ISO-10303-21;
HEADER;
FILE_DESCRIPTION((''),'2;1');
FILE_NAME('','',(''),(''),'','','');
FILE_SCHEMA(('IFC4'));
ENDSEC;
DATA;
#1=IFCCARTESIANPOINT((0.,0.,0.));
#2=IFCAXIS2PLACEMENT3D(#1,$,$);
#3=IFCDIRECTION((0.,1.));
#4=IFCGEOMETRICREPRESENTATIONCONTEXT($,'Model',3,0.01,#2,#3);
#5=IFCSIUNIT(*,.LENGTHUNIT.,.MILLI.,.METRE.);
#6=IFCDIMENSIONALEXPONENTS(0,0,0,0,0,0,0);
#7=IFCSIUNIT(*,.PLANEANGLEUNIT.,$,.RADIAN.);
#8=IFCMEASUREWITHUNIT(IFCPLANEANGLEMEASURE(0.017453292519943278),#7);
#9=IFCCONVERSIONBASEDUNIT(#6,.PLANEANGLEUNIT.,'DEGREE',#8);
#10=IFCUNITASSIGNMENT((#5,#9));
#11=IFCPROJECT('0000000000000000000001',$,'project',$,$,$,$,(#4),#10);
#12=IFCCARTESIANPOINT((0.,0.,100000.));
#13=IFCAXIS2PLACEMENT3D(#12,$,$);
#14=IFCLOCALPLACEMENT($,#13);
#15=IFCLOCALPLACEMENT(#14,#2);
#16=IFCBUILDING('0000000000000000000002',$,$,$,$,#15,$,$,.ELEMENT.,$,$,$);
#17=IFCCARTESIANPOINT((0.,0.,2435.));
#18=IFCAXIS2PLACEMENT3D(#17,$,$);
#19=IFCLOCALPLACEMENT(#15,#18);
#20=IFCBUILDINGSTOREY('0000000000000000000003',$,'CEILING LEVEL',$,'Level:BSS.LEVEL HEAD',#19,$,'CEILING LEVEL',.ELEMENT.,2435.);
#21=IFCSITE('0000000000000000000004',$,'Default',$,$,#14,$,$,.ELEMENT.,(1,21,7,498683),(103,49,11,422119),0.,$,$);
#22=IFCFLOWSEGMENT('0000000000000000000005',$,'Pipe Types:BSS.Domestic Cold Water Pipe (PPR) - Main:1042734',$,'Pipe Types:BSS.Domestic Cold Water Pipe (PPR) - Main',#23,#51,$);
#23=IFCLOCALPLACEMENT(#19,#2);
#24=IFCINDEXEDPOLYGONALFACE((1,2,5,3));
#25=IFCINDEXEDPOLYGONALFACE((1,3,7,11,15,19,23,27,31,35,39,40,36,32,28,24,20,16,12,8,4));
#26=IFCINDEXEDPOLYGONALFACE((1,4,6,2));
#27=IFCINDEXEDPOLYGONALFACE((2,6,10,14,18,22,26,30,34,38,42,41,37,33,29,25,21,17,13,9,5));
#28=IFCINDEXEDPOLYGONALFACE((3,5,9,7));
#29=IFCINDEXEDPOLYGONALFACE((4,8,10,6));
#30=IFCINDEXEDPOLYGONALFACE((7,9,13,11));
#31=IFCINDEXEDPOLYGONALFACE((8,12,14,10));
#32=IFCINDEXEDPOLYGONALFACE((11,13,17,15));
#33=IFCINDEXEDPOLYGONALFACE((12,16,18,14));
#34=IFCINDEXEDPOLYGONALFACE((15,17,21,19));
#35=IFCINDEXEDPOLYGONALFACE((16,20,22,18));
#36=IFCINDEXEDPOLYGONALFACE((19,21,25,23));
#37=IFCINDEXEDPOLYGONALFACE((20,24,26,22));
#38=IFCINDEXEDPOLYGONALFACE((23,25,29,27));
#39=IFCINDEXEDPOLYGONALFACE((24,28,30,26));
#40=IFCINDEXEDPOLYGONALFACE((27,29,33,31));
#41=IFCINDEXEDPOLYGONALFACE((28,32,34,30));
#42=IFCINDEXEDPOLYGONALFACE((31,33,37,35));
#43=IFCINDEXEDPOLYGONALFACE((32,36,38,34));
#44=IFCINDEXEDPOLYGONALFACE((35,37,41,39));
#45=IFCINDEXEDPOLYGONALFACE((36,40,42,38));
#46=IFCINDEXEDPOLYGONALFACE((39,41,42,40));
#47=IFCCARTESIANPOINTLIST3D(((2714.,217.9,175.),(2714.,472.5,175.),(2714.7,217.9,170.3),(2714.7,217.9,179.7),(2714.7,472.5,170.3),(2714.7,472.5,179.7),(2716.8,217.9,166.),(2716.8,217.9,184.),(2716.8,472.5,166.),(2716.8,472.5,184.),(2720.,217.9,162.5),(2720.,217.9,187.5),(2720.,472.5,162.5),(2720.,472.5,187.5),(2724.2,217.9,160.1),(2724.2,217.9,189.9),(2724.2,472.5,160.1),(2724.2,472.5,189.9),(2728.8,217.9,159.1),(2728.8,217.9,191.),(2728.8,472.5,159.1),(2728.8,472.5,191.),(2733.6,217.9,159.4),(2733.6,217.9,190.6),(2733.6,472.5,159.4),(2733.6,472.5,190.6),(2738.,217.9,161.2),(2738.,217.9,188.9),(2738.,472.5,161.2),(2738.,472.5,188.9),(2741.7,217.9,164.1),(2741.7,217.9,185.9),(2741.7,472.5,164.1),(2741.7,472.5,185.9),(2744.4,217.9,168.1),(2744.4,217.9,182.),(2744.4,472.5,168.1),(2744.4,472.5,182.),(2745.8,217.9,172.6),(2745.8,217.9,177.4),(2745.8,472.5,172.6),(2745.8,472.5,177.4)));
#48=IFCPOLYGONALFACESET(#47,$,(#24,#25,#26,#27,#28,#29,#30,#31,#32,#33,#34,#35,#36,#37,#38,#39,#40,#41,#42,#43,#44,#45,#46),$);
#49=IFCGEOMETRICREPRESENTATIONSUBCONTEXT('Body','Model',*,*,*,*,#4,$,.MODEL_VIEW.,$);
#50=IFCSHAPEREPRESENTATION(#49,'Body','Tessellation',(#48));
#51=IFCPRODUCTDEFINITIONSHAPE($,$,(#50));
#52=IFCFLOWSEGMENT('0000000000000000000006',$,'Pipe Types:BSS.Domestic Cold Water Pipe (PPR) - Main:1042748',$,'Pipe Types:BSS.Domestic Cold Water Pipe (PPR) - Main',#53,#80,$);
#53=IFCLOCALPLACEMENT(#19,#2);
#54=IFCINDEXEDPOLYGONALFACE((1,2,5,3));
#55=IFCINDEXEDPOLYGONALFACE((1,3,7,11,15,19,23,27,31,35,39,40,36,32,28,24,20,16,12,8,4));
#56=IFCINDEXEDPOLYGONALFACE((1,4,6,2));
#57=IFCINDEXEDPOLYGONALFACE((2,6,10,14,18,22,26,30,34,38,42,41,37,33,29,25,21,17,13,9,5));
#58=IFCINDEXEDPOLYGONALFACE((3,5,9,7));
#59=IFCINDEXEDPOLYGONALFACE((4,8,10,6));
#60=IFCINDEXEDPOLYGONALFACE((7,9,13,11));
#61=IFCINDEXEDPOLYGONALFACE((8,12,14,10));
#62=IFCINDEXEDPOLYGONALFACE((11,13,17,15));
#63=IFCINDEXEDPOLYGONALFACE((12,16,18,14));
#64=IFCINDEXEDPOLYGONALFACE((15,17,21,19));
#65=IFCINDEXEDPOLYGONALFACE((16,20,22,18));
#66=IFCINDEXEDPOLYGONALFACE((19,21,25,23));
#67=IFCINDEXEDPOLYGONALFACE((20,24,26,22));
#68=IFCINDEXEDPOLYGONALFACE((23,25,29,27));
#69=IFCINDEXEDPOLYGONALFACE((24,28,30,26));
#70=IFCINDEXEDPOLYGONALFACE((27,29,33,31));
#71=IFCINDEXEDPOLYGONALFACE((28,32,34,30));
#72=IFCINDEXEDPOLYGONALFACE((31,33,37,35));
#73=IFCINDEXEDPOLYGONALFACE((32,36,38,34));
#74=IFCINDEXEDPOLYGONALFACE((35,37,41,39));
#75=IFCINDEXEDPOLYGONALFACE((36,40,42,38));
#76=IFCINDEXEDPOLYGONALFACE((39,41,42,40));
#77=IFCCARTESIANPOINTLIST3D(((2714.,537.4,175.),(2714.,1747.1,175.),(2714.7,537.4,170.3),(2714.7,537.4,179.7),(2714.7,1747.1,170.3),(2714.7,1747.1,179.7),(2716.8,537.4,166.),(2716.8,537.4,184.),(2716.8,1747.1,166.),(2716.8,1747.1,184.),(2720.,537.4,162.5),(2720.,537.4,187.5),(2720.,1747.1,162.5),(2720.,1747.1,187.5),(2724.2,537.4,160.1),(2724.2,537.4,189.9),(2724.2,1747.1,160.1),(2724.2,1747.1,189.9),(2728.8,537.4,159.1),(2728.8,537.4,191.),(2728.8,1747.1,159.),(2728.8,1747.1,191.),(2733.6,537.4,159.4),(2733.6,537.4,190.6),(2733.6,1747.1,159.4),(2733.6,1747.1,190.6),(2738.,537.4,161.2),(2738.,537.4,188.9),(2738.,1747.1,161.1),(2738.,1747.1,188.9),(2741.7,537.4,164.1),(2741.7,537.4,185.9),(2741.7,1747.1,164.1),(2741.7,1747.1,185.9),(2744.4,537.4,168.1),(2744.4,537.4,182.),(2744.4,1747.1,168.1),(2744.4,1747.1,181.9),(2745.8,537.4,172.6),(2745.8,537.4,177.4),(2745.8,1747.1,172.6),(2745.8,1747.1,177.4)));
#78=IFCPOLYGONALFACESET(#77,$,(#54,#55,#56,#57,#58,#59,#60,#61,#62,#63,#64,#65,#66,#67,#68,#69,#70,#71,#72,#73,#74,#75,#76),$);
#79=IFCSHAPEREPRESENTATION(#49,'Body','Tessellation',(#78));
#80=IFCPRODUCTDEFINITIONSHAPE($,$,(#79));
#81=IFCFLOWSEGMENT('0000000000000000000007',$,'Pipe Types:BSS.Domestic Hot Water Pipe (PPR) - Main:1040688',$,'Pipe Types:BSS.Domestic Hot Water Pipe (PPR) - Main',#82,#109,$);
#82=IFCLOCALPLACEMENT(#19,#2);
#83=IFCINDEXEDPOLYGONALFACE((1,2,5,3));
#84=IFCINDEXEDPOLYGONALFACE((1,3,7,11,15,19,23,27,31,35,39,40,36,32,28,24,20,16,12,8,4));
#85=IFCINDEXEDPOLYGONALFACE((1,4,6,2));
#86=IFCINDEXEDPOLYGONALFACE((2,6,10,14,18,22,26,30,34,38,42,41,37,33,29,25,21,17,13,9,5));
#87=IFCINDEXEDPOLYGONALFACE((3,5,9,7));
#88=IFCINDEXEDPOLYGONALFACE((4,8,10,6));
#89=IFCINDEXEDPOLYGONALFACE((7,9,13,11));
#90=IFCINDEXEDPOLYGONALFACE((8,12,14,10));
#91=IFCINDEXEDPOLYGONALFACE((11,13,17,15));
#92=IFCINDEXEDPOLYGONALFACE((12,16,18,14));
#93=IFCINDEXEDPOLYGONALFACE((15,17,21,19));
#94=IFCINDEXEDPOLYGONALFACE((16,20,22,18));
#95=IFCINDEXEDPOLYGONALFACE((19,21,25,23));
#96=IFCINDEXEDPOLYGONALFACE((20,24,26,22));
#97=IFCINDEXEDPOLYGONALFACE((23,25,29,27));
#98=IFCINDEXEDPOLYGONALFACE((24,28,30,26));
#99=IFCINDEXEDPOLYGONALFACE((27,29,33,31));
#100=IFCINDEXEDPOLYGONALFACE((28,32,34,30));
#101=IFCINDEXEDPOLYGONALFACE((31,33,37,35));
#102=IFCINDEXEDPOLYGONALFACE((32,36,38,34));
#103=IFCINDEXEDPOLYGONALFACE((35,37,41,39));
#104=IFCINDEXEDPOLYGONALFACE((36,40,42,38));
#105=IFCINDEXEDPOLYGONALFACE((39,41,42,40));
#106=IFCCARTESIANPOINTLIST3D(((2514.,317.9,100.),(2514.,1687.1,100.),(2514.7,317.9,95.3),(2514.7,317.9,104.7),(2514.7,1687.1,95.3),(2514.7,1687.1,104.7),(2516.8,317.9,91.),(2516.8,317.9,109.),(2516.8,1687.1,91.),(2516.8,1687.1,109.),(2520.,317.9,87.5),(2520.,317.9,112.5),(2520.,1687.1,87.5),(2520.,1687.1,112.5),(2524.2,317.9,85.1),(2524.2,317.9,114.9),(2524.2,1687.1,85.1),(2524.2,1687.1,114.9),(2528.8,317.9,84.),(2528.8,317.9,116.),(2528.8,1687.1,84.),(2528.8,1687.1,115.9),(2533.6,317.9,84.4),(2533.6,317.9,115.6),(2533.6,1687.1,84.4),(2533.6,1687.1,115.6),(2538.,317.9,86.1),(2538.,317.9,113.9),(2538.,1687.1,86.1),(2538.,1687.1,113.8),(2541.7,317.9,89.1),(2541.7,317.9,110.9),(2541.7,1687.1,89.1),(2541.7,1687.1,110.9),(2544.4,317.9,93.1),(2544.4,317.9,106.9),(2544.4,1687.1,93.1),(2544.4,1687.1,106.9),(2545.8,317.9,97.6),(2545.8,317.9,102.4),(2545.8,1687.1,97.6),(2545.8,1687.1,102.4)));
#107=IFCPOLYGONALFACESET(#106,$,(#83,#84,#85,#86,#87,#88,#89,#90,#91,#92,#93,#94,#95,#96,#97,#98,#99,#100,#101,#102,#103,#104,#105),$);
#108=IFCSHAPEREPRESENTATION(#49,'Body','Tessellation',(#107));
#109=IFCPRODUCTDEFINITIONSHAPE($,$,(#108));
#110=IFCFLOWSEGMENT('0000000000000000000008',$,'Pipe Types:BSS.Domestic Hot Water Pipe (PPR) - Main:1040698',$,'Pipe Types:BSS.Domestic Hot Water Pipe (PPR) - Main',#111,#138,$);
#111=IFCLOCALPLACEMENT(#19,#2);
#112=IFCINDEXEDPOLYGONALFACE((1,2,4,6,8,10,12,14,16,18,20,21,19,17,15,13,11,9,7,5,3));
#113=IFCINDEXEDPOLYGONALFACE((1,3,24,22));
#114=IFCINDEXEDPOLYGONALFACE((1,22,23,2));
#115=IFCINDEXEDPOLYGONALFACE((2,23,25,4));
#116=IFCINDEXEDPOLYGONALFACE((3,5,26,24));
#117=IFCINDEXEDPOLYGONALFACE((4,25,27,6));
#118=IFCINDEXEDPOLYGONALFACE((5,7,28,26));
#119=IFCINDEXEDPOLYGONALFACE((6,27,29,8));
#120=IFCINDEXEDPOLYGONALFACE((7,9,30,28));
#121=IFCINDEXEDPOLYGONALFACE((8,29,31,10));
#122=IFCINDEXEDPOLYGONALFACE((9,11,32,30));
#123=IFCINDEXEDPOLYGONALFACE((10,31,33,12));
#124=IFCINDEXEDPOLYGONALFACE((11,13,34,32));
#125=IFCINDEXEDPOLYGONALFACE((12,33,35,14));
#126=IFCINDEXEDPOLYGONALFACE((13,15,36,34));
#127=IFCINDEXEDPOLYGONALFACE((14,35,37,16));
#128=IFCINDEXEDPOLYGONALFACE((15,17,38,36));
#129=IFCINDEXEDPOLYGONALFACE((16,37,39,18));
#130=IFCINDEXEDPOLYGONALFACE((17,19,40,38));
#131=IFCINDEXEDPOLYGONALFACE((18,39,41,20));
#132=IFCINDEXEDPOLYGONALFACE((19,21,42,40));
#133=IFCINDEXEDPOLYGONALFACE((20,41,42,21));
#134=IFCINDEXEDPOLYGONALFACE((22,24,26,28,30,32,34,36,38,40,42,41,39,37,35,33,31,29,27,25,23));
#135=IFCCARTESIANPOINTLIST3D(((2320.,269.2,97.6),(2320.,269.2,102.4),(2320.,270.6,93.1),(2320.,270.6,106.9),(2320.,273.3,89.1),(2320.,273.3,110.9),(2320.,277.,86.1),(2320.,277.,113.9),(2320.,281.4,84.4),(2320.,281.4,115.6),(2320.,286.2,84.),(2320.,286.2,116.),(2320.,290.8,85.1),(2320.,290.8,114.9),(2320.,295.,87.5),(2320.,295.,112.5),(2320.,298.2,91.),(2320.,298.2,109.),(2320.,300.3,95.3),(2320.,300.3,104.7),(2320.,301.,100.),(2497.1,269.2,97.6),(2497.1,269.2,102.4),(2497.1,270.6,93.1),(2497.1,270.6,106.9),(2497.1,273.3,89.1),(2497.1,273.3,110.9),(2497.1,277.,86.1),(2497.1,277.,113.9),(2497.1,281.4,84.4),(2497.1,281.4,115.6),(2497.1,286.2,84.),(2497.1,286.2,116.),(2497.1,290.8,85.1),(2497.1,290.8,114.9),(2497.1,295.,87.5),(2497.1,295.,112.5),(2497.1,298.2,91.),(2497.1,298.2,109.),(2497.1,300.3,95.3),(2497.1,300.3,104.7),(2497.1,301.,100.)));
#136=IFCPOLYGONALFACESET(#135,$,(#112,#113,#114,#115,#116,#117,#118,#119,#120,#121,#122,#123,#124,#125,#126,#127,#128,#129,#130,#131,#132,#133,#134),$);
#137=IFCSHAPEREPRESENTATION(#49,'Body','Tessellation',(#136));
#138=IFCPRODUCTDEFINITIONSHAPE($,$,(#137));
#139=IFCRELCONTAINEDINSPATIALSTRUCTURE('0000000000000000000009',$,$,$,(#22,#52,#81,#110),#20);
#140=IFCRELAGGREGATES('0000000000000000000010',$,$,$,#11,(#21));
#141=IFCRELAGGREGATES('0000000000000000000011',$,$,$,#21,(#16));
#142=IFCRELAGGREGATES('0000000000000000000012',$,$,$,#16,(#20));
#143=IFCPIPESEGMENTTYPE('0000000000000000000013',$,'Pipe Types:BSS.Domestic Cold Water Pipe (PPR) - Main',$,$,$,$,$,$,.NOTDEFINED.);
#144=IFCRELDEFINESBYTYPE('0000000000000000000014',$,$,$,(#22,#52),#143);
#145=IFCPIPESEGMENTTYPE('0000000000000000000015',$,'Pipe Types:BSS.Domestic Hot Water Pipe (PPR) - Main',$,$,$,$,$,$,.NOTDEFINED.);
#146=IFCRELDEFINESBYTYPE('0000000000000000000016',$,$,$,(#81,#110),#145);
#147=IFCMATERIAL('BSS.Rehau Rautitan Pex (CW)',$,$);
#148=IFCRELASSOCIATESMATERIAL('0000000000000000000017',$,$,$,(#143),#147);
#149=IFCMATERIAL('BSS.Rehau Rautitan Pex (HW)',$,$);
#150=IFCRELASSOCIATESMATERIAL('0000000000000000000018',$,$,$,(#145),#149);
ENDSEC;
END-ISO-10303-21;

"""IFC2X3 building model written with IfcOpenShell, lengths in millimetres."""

from ifc_helpers import new_model, entity, si_unit, converted_unit, direction, frame, frame_2d, origin, origin_2d_with_axis, place, context, subcontext, project, spatial, circle, extrude, material, type_object, element, save


model = new_model("IFC2X3")

# Units and contexts
model_context = context("Model", 3, precision=0.01, world=origin(), true_north=direction((0.0, 1.0)))
body_context = subcontext(model_context, "Body", "Model", "MODEL_VIEW")
ifc_project = project(units=[si_unit("LENGTHUNIT", "METRE", prefix="MILLI"), converted_unit("PLANEANGLEUNIT", "DEGREE", entity("IfcPlaneAngleMeasure", 0.017453292519943278), si_unit("PLANEANGLEUNIT", "RADIAN"), dimensions=[0, 0, 0, 0, 0, 0, 0])], contexts=[model_context])

# Site, building, storey
site_placement = place(None, frame((0.0, 0.0, 100000.0)))
site = spatial("IfcSite", under=ifc_project, at=site_placement, Name="Default", CompositionType="ELEMENT", RefLatitude=(1, 21, 7, 498683), RefLongitude=(103, 49, 11, 422119), RefElevation=0.0)
building_placement = place(site_placement, origin())
building = spatial("IfcBuilding", under=site, at=building_placement, CompositionType="ELEMENT")
storey_placement = place(building_placement, frame((0.0, 0.0, 2435.0)))
storey = spatial("IfcBuildingStorey", under=building, at=storey_placement, Name="CEILING LEVEL", ObjectType="Level:BSS.LEVEL HEAD", LongName="CEILING LEVEL", CompositionType="ELEMENT", Elevation=2435.0)

# Flow segments
ifc_material_1 = material(Name="BSS.Rehau Rautitan Pex (HW)")
ifc_material_2 = material(Name="BSS.Rehau Rautitan Pex (CW)")
pipe_segment_type_1 = type_object("IfcPipeSegmentType", Name="Pipe Types:BSS.Domestic Cold Water Pipe (PPR) - Main", PredefinedType="NOTDEFINED", material=ifc_material_2)
flow_segment_1_placement = place(storey_placement, origin())
element("IfcFlowSegment", 1, at=flow_segment_1_placement, inside=storey, type_object=pipe_segment_type_1, Name="Pipe Types:BSS.Domestic Cold Water Pipe (PPR) - Main:1042734", ObjectType="Pipe Types:BSS.Domestic Cold Water Pipe (PPR) - Main", context=body_context, shape_type="SweptSolid", body=[
    extrude(circle(Radius=16.0, at=origin_2d_with_axis()), frame((2730.0, 472.5, 175.0), z_axis=(0.0, -1.0, 0.000032), x_axis=(-1.0, 0.0, 0.0)), (0.0, 0.0, 1.0), 254.7),
])
flow_segment_2_placement = place(storey_placement, origin())
element("IfcFlowSegment", 2, at=flow_segment_2_placement, inside=storey, type_object=pipe_segment_type_1, Name="Pipe Types:BSS.Domestic Cold Water Pipe (PPR) - Main:1042748", ObjectType="Pipe Types:BSS.Domestic Cold Water Pipe (PPR) - Main", context=body_context, shape_type="SweptSolid", body=[
    extrude(circle(Radius=16.0, at=frame_2d((0.0, 0.0), x_axis=(1.0, 0.0))), frame((2730.0, 537.4, 175.0), z_axis=(0.0, 1.0, -0.000008), x_axis=(-1.0, 0.0, 0.0)), (0.0, 0.0, 1.0), 1209.7),
])
pipe_segment_type_2 = type_object("IfcPipeSegmentType", Name="Pipe Types:BSS.Domestic Hot Water Pipe (PPR) - Main", PredefinedType="NOTDEFINED", material=ifc_material_1)
flow_segment_3_placement = place(storey_placement, origin())
element("IfcFlowSegment", 3, at=flow_segment_3_placement, inside=storey, type_object=pipe_segment_type_2, Name="Pipe Types:BSS.Domestic Hot Water Pipe (PPR) - Main:1040688", ObjectType="Pipe Types:BSS.Domestic Hot Water Pipe (PPR) - Main", context=body_context, shape_type="SweptSolid", body=[
    extrude(circle(Radius=16.0, at=origin_2d_with_axis()), frame((2530.0, 317.9, 100.0), z_axis=(0.0, 1.0, -0.000003), x_axis=(-1.0, 0.0, 0.0)), (0.0, 0.0, 1.0), 1369.3),
])
flow_segment_4_placement = place(storey_placement, origin())
element("IfcFlowSegment", 4, at=flow_segment_4_placement, inside=storey, type_object=pipe_segment_type_2, Name="Pipe Types:BSS.Domestic Hot Water Pipe (PPR) - Main:1040698", ObjectType="Pipe Types:BSS.Domestic Hot Water Pipe (PPR) - Main", context=body_context, shape_type="SweptSolid", body=[
    extrude(circle(Radius=16.0, at=origin_2d_with_axis()), frame((2320.0, 285.0, 100.0), z_axis=(1.0, 0.0, 0.0), x_axis=(0.0, 1.0, 0.0)), (0.0, 0.0, 1.0), 177.1),
])

save(model, "model.ifc")
